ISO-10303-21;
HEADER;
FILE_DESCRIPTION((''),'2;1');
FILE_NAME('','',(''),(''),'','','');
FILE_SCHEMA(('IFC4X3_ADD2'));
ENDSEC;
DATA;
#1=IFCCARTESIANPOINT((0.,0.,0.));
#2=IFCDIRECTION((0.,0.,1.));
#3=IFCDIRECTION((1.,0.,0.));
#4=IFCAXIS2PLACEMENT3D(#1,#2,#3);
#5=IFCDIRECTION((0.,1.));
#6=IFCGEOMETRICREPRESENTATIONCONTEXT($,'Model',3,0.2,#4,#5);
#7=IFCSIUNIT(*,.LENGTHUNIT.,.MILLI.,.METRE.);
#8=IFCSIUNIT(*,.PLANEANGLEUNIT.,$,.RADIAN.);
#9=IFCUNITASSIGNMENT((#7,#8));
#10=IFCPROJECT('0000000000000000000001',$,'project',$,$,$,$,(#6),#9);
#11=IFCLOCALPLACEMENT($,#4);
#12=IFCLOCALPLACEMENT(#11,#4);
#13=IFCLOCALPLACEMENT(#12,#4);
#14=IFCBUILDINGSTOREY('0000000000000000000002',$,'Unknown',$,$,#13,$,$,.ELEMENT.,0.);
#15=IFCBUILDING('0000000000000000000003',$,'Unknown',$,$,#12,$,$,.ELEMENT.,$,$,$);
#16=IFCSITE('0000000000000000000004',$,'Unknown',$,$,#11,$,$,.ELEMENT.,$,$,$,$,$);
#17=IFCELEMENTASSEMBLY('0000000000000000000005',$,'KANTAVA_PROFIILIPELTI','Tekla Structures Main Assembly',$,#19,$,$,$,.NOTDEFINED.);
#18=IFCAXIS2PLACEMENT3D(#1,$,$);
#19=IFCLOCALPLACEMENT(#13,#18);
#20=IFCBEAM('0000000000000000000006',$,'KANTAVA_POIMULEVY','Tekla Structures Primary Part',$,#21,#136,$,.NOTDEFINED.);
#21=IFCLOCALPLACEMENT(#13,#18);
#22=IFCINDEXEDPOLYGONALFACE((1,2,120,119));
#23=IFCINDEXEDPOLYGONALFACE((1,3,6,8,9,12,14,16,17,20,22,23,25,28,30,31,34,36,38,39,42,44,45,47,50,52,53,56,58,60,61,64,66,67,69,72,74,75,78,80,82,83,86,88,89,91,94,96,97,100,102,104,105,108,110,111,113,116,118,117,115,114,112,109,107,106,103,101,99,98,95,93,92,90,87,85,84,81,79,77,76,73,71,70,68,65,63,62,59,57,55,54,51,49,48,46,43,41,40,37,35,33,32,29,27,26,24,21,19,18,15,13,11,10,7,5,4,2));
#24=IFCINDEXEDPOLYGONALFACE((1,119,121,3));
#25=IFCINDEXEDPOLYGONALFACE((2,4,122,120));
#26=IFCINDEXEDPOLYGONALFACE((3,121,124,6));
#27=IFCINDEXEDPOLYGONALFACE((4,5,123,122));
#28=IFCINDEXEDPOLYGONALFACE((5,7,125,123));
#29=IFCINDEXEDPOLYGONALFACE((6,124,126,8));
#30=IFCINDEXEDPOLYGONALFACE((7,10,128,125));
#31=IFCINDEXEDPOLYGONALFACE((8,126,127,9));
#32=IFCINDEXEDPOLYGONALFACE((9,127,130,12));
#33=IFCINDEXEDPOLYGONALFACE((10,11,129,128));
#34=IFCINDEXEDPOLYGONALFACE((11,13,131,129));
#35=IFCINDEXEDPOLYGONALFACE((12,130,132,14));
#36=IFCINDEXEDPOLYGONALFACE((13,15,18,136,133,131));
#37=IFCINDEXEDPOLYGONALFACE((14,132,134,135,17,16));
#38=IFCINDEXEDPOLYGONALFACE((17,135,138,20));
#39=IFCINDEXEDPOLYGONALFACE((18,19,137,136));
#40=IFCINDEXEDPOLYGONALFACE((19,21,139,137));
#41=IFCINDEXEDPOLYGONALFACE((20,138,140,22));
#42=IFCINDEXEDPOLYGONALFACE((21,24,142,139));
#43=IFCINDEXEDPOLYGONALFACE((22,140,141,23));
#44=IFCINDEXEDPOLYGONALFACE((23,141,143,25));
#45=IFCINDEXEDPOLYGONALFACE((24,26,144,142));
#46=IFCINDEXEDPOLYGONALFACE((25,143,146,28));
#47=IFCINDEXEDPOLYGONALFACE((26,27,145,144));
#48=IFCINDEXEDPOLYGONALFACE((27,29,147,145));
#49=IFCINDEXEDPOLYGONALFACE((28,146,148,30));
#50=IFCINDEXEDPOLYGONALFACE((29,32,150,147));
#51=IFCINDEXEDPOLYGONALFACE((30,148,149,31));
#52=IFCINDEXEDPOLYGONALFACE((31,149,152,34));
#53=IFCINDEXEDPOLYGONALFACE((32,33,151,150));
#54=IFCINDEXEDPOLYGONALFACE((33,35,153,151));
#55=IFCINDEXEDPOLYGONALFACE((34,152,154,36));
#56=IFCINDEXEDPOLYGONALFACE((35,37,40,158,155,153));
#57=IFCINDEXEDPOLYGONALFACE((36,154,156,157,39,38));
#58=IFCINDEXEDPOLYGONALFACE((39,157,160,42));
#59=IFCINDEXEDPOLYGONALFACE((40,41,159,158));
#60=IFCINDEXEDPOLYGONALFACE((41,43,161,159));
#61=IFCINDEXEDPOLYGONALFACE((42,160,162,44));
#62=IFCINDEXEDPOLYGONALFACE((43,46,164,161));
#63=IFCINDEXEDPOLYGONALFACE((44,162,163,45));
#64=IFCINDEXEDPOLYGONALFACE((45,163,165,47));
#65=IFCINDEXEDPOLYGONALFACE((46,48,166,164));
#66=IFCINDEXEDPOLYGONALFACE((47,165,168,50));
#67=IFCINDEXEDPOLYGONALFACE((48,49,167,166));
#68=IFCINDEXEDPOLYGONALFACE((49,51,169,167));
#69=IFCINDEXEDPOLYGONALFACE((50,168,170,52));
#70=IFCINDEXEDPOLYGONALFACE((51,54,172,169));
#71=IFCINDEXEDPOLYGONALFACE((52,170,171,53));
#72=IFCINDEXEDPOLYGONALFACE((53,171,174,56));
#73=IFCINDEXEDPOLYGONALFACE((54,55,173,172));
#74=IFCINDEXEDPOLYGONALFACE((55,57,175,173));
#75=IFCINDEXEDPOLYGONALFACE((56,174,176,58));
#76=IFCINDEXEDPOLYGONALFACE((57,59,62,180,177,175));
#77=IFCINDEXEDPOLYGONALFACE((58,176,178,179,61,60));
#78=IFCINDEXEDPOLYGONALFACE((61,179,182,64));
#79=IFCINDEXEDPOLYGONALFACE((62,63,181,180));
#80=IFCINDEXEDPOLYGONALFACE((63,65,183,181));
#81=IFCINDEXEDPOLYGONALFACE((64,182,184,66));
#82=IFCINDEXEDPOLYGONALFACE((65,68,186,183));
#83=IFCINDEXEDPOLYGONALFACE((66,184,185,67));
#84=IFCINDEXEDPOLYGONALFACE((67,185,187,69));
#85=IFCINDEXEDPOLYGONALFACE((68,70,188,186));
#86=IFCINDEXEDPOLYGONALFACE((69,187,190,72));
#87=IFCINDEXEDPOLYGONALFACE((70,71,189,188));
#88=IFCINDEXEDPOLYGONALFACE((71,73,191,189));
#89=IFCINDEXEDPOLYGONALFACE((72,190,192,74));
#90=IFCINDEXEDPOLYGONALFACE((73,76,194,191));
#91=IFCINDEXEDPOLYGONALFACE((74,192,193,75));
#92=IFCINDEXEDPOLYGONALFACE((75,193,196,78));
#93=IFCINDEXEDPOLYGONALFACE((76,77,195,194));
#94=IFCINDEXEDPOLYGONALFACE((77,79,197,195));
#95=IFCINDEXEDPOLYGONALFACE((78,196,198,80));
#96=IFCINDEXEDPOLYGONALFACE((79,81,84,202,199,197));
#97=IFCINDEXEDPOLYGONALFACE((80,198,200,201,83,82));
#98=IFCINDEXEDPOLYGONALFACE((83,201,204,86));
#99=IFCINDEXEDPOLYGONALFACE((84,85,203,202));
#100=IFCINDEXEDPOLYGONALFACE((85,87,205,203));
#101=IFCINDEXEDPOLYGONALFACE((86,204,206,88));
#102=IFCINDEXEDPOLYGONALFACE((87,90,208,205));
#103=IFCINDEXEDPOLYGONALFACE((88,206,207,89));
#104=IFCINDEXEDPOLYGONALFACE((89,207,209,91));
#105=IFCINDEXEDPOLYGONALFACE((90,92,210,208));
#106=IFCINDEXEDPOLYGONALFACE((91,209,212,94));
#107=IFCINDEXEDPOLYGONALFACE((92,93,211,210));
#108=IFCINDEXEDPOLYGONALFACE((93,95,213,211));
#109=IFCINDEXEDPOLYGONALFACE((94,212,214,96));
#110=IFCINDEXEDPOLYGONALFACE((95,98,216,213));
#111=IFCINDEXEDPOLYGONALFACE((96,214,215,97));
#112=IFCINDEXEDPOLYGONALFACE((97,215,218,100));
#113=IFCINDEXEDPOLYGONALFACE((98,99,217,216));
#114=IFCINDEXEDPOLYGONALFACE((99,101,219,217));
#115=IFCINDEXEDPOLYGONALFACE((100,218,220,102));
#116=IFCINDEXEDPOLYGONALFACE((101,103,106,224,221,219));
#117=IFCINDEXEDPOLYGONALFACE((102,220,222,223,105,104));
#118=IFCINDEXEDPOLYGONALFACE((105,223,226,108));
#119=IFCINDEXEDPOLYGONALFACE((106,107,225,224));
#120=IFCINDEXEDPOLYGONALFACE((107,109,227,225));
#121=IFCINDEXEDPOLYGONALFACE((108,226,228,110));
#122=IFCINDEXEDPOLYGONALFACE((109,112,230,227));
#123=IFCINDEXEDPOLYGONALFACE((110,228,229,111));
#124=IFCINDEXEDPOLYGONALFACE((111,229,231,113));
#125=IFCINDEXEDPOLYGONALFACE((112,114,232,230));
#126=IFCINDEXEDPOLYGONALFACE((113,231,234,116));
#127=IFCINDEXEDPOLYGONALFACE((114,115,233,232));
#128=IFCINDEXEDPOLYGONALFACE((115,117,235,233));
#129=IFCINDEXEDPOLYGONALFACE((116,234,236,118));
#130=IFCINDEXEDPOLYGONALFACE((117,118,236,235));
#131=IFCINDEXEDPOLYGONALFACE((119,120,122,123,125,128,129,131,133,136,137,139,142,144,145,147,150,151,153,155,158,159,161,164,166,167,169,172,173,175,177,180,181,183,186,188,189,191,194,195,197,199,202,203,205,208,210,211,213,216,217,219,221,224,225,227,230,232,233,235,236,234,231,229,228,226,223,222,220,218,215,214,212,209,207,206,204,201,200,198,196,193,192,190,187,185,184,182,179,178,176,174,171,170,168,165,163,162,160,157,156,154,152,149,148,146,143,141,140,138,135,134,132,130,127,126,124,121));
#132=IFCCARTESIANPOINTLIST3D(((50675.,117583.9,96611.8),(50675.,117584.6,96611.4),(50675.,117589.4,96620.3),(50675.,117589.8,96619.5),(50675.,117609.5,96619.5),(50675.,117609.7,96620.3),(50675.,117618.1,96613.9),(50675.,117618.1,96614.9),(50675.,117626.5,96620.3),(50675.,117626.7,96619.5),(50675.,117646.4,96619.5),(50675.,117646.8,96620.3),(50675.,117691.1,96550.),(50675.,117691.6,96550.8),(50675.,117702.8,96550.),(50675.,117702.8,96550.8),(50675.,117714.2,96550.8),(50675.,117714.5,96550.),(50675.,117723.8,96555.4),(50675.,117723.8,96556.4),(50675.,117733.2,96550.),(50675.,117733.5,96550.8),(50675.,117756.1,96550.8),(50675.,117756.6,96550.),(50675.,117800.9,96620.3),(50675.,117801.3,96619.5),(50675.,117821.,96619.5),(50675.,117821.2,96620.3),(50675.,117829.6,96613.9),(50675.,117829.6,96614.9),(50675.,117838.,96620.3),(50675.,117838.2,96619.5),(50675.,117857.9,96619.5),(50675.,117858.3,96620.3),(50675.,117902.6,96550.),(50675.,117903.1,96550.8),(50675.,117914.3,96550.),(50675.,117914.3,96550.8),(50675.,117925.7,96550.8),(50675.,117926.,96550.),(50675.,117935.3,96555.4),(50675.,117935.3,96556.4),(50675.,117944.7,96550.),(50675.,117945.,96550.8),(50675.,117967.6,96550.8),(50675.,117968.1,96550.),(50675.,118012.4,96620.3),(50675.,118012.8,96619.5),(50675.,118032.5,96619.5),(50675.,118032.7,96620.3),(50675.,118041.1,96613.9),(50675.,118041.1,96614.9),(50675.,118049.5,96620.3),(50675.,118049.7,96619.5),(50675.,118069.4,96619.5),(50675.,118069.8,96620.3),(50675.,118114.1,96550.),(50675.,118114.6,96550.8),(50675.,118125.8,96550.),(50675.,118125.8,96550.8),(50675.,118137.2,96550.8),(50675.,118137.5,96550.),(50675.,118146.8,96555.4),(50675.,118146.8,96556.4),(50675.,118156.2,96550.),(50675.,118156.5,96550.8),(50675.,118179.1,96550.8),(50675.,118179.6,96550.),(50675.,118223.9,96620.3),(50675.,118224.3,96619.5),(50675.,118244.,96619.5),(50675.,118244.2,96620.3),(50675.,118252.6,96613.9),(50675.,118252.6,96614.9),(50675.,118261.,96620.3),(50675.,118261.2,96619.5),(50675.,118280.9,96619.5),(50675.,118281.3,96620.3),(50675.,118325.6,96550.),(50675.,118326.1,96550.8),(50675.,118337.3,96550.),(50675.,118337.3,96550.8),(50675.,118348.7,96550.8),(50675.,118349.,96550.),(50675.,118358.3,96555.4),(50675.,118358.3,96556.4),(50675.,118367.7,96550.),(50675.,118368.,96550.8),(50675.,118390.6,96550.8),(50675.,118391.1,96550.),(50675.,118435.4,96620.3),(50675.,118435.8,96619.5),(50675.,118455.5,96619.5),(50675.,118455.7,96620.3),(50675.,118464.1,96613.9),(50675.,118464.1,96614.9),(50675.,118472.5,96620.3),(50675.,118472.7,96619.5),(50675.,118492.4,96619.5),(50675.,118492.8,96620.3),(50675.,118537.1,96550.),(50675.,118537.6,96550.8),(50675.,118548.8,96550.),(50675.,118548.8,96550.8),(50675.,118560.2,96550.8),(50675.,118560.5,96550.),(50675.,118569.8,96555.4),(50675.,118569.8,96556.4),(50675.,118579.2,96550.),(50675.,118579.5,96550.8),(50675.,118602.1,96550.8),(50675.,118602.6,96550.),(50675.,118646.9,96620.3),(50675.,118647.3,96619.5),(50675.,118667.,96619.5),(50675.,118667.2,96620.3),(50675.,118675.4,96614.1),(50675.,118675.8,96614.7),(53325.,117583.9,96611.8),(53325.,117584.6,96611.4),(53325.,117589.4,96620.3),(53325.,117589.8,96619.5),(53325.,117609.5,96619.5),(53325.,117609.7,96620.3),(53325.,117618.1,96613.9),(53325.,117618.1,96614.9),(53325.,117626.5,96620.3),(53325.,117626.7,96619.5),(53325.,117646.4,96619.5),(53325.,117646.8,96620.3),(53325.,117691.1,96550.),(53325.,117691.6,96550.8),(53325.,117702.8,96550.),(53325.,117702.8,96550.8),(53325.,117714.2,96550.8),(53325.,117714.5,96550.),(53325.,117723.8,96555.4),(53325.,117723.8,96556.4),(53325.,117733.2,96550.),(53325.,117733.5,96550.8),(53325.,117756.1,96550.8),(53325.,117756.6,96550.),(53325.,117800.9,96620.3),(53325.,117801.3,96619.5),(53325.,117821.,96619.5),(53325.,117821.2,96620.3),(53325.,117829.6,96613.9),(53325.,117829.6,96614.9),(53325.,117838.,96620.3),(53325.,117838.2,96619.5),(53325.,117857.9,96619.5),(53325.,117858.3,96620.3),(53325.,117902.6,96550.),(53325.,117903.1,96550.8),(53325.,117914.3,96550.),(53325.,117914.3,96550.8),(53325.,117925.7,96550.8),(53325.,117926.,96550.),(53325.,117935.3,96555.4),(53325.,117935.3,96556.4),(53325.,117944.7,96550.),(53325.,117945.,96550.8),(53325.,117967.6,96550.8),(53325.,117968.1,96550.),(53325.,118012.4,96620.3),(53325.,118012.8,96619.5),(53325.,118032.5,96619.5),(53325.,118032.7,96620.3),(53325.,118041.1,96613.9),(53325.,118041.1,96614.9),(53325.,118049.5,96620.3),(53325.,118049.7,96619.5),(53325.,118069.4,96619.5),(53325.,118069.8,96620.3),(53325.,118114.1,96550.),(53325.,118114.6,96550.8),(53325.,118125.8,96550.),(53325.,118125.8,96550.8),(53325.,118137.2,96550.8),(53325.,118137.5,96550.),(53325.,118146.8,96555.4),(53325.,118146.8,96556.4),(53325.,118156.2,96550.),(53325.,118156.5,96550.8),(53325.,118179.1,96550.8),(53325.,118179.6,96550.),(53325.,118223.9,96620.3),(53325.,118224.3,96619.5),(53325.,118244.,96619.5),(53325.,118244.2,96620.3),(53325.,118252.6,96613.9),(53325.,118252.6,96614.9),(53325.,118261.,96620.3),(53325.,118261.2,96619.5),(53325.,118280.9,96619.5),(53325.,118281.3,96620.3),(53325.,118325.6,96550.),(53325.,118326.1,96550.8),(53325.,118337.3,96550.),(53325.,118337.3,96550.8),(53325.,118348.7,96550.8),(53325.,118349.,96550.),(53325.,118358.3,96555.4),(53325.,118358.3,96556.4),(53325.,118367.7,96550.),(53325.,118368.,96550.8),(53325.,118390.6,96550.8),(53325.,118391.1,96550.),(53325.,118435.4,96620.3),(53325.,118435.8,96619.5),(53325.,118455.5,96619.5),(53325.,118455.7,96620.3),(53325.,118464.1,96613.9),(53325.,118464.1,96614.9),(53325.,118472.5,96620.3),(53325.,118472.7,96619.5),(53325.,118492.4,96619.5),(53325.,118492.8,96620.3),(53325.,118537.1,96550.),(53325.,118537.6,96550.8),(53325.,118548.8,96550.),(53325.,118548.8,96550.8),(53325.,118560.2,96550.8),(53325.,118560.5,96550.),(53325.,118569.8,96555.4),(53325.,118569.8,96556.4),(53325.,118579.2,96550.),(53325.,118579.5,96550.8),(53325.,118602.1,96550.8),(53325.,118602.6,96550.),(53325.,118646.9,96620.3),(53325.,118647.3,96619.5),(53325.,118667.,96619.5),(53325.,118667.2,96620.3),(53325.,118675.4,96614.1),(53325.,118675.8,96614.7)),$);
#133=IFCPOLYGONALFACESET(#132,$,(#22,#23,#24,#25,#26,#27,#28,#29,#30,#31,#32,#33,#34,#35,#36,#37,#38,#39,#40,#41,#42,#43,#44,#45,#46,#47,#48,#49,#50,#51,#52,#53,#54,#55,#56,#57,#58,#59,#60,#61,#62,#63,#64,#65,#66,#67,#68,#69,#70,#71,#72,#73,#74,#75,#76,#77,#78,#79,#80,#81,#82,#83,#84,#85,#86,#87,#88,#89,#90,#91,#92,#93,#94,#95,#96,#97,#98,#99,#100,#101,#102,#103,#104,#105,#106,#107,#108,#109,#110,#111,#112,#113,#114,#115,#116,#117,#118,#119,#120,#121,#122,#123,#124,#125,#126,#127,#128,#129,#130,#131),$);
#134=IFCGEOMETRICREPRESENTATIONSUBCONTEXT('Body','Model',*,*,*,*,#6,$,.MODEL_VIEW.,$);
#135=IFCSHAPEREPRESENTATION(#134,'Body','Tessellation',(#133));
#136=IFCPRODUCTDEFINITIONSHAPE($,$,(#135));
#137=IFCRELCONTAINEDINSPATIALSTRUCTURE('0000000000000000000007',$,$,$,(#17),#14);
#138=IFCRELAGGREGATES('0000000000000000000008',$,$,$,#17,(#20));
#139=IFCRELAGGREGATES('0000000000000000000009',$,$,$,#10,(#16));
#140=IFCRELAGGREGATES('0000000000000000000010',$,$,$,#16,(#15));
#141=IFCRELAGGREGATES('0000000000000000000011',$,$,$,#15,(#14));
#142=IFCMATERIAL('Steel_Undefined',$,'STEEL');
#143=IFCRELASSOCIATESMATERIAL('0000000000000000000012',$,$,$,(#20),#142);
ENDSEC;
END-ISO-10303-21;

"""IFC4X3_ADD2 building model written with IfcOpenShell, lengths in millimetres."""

from ifc_helpers import new_model, si_unit, direction, frame, origin_with_axes, place, context, subcontext, project, spatial, line, indexed_curve, outline, extrude, material, element, aggregate, save


model = new_model("IFC4X3_ADD2")

# Units and contexts
model_context = context("Model", 3, precision=0.2, world=origin_with_axes(), true_north=direction((0.0, 1.0)))
body_context = subcontext(model_context, "Body", "Model", "MODEL_VIEW")
ifc_project = project(units=[si_unit("LENGTHUNIT", "METRE", prefix="MILLI"), si_unit("PLANEANGLEUNIT", "RADIAN")], contexts=[model_context])

# Site, building, storey
site_placement = place(None, origin_with_axes())
site = spatial("IfcSite", under=ifc_project, at=site_placement, Name="Unknown", CompositionType="ELEMENT")
building_placement = place(site_placement, origin_with_axes())
building = spatial("IfcBuilding", under=site, at=building_placement, Name="Unknown", CompositionType="ELEMENT")
storey_placement = place(building_placement, origin_with_axes())
storey = spatial("IfcBuildingStorey", under=building, at=storey_placement, Name="Unknown", CompositionType="ELEMENT", Elevation=0.0)

# Element assembly, beam
ifc_material_1 = material(Name="Steel_Undefined", Category="STEEL")
assembly_1_placement = place(storey_placement, frame((53325.0, 118146.8, 96585.2), z_axis=(0.0, 1.0, 0.0), x_axis=(-1.0, 0.0, 0.0)))
assembly_1 = element("IfcElementAssembly", 1, at=assembly_1_placement, inside=storey, Name="KANTAVA_PROFIILIPELTI", Description="Tekla Structures Main Assembly", PredefinedType="NOTDEFINED")
beam_1_placement = place(assembly_1_placement, origin_with_axes())
beam_1 = element("IfcBeam", 2, at=beam_1_placement, material=ifc_material_1, Name="KANTAVA_POIMULEVY", Description="Tekla Structures Primary Part", PredefinedType="NOTDEFINED", context=body_context, shape_type="SolidModel", body=[
    extrude(outline(indexed_curve([(529.0, 29.6), (520.4, 35.1), (500.0, 35.1), (455.3, -34.4), (432.6, -34.4), (423.0, -28.8), (413.4, -34.4), (402.0, -34.4), (390.7, -34.4), (346.0, 35.1), (325.6, 35.1), (317.2, 29.7), (308.9, 35.1), (288.5, 35.1), (243.8, -34.4), (221.1, -34.4), (211.5, -28.8), (201.9, -34.4), (190.5, -34.4), (179.2, -34.4), (134.5, 35.1), (114.1, 35.1), (105.8, 29.7), (97.4, 35.1), (77.0, 35.1), (32.3, -34.4), (9.6, -34.4), (0.0, -28.8), (-9.6, -34.4), (-21.0, -34.4), (-32.3, -34.4), (-77.0, 35.1), (-97.4, 35.1), (-105.8, 29.7), (-114.1, 35.1), (-134.5, 35.1), (-179.2, -34.4), (-201.9, -34.4), (-211.5, -28.8), (-221.1, -34.4), (-232.5, -34.4), (-243.8, -34.4), (-288.5, 35.1), (-308.9, 35.1), (-317.2, 29.7), (-325.6, 35.1), (-346.0, 35.1), (-390.7, -34.4), (-413.4, -34.4), (-423.0, -28.8), (-432.6, -34.4), (-444.0, -34.4), (-455.3, -34.4), (-500.0, 35.1), (-520.4, 35.1), (-528.8, 29.7), (-537.1, 35.1), (-557.5, 35.1), (-562.9, 26.7), (-562.2, 26.2), (-557.0, 34.4), (-537.4, 34.4), (-528.8, 28.8), (-520.1, 34.4), (-500.5, 34.4), (-455.7, -35.1), (-444.0, -35.1), (-432.4, -35.1), (-423.0, -29.7), (-413.6, -35.1), (-390.3, -35.1), (-345.5, 34.4), (-325.9, 34.4), (-317.2, 28.8), (-308.6, 34.4), (-289.0, 34.4), (-244.2, -35.1), (-232.5, -35.1), (-220.9, -35.1), (-211.5, -29.7), (-202.1, -35.1), (-178.8, -35.1), (-134.0, 34.4), (-114.4, 34.4), (-105.8, 28.8), (-97.1, 34.4), (-77.5, 34.4), (-32.7, -35.1), (-21.0, -35.1), (-9.4, -35.1), (0.0, -29.7), (9.4, -35.1), (32.7, -35.1), (77.5, 34.4), (97.1, 34.4), (105.8, 28.8), (114.4, 34.4), (134.0, 34.4), (178.8, -35.1), (190.5, -35.1), (202.1, -35.1), (211.5, -29.7), (220.9, -35.1), (244.2, -35.1), (289.0, 34.4), (308.6, 34.4), (317.2, 28.8), (325.9, 34.4), (345.5, 34.4), (390.3, -35.1), (402.0, -35.1), (413.6, -35.1), (423.0, -29.7), (432.4, -35.1), (455.7, -35.1), (500.5, 34.4), (520.1, 34.4), (528.5, 28.9)], segments=[line(1, 2, 3, 4, 5, 6, 7, 8, 9, 10, 11, 12, 13, 14, 15, 16, 17, 18, 19, 20, 21, 22, 23, 24, 25, 26, 27, 28, 29, 30, 31, 32, 33, 34, 35, 36, 37, 38, 39, 40, 41, 42, 43, 44, 45, 46, 47, 48, 49, 50, 51, 52, 53, 54, 55, 56, 57, 58, 59, 60, 61, 62, 63, 64, 65, 66, 67, 68, 69, 70, 71, 72, 73, 74, 75, 76, 77, 78, 79, 80, 81, 82, 83, 84, 85, 86, 87, 88, 89, 90, 91, 92, 93, 94, 95, 96, 97, 98, 99, 100, 101, 102, 103, 104, 105, 106, 107, 108, 109, 110, 111, 112, 113, 114, 115, 116, 117, 118, 1)])), frame((0.0, 0.0, 0.0), z_axis=(-1.0, 0.0, 0.0), x_axis=(0.0, 0.0, 1.0)), (0.0, 0.0, -1.0), 2650.0),
])
aggregate(assembly_1, [beam_1])

save(model, "model.ifc")
